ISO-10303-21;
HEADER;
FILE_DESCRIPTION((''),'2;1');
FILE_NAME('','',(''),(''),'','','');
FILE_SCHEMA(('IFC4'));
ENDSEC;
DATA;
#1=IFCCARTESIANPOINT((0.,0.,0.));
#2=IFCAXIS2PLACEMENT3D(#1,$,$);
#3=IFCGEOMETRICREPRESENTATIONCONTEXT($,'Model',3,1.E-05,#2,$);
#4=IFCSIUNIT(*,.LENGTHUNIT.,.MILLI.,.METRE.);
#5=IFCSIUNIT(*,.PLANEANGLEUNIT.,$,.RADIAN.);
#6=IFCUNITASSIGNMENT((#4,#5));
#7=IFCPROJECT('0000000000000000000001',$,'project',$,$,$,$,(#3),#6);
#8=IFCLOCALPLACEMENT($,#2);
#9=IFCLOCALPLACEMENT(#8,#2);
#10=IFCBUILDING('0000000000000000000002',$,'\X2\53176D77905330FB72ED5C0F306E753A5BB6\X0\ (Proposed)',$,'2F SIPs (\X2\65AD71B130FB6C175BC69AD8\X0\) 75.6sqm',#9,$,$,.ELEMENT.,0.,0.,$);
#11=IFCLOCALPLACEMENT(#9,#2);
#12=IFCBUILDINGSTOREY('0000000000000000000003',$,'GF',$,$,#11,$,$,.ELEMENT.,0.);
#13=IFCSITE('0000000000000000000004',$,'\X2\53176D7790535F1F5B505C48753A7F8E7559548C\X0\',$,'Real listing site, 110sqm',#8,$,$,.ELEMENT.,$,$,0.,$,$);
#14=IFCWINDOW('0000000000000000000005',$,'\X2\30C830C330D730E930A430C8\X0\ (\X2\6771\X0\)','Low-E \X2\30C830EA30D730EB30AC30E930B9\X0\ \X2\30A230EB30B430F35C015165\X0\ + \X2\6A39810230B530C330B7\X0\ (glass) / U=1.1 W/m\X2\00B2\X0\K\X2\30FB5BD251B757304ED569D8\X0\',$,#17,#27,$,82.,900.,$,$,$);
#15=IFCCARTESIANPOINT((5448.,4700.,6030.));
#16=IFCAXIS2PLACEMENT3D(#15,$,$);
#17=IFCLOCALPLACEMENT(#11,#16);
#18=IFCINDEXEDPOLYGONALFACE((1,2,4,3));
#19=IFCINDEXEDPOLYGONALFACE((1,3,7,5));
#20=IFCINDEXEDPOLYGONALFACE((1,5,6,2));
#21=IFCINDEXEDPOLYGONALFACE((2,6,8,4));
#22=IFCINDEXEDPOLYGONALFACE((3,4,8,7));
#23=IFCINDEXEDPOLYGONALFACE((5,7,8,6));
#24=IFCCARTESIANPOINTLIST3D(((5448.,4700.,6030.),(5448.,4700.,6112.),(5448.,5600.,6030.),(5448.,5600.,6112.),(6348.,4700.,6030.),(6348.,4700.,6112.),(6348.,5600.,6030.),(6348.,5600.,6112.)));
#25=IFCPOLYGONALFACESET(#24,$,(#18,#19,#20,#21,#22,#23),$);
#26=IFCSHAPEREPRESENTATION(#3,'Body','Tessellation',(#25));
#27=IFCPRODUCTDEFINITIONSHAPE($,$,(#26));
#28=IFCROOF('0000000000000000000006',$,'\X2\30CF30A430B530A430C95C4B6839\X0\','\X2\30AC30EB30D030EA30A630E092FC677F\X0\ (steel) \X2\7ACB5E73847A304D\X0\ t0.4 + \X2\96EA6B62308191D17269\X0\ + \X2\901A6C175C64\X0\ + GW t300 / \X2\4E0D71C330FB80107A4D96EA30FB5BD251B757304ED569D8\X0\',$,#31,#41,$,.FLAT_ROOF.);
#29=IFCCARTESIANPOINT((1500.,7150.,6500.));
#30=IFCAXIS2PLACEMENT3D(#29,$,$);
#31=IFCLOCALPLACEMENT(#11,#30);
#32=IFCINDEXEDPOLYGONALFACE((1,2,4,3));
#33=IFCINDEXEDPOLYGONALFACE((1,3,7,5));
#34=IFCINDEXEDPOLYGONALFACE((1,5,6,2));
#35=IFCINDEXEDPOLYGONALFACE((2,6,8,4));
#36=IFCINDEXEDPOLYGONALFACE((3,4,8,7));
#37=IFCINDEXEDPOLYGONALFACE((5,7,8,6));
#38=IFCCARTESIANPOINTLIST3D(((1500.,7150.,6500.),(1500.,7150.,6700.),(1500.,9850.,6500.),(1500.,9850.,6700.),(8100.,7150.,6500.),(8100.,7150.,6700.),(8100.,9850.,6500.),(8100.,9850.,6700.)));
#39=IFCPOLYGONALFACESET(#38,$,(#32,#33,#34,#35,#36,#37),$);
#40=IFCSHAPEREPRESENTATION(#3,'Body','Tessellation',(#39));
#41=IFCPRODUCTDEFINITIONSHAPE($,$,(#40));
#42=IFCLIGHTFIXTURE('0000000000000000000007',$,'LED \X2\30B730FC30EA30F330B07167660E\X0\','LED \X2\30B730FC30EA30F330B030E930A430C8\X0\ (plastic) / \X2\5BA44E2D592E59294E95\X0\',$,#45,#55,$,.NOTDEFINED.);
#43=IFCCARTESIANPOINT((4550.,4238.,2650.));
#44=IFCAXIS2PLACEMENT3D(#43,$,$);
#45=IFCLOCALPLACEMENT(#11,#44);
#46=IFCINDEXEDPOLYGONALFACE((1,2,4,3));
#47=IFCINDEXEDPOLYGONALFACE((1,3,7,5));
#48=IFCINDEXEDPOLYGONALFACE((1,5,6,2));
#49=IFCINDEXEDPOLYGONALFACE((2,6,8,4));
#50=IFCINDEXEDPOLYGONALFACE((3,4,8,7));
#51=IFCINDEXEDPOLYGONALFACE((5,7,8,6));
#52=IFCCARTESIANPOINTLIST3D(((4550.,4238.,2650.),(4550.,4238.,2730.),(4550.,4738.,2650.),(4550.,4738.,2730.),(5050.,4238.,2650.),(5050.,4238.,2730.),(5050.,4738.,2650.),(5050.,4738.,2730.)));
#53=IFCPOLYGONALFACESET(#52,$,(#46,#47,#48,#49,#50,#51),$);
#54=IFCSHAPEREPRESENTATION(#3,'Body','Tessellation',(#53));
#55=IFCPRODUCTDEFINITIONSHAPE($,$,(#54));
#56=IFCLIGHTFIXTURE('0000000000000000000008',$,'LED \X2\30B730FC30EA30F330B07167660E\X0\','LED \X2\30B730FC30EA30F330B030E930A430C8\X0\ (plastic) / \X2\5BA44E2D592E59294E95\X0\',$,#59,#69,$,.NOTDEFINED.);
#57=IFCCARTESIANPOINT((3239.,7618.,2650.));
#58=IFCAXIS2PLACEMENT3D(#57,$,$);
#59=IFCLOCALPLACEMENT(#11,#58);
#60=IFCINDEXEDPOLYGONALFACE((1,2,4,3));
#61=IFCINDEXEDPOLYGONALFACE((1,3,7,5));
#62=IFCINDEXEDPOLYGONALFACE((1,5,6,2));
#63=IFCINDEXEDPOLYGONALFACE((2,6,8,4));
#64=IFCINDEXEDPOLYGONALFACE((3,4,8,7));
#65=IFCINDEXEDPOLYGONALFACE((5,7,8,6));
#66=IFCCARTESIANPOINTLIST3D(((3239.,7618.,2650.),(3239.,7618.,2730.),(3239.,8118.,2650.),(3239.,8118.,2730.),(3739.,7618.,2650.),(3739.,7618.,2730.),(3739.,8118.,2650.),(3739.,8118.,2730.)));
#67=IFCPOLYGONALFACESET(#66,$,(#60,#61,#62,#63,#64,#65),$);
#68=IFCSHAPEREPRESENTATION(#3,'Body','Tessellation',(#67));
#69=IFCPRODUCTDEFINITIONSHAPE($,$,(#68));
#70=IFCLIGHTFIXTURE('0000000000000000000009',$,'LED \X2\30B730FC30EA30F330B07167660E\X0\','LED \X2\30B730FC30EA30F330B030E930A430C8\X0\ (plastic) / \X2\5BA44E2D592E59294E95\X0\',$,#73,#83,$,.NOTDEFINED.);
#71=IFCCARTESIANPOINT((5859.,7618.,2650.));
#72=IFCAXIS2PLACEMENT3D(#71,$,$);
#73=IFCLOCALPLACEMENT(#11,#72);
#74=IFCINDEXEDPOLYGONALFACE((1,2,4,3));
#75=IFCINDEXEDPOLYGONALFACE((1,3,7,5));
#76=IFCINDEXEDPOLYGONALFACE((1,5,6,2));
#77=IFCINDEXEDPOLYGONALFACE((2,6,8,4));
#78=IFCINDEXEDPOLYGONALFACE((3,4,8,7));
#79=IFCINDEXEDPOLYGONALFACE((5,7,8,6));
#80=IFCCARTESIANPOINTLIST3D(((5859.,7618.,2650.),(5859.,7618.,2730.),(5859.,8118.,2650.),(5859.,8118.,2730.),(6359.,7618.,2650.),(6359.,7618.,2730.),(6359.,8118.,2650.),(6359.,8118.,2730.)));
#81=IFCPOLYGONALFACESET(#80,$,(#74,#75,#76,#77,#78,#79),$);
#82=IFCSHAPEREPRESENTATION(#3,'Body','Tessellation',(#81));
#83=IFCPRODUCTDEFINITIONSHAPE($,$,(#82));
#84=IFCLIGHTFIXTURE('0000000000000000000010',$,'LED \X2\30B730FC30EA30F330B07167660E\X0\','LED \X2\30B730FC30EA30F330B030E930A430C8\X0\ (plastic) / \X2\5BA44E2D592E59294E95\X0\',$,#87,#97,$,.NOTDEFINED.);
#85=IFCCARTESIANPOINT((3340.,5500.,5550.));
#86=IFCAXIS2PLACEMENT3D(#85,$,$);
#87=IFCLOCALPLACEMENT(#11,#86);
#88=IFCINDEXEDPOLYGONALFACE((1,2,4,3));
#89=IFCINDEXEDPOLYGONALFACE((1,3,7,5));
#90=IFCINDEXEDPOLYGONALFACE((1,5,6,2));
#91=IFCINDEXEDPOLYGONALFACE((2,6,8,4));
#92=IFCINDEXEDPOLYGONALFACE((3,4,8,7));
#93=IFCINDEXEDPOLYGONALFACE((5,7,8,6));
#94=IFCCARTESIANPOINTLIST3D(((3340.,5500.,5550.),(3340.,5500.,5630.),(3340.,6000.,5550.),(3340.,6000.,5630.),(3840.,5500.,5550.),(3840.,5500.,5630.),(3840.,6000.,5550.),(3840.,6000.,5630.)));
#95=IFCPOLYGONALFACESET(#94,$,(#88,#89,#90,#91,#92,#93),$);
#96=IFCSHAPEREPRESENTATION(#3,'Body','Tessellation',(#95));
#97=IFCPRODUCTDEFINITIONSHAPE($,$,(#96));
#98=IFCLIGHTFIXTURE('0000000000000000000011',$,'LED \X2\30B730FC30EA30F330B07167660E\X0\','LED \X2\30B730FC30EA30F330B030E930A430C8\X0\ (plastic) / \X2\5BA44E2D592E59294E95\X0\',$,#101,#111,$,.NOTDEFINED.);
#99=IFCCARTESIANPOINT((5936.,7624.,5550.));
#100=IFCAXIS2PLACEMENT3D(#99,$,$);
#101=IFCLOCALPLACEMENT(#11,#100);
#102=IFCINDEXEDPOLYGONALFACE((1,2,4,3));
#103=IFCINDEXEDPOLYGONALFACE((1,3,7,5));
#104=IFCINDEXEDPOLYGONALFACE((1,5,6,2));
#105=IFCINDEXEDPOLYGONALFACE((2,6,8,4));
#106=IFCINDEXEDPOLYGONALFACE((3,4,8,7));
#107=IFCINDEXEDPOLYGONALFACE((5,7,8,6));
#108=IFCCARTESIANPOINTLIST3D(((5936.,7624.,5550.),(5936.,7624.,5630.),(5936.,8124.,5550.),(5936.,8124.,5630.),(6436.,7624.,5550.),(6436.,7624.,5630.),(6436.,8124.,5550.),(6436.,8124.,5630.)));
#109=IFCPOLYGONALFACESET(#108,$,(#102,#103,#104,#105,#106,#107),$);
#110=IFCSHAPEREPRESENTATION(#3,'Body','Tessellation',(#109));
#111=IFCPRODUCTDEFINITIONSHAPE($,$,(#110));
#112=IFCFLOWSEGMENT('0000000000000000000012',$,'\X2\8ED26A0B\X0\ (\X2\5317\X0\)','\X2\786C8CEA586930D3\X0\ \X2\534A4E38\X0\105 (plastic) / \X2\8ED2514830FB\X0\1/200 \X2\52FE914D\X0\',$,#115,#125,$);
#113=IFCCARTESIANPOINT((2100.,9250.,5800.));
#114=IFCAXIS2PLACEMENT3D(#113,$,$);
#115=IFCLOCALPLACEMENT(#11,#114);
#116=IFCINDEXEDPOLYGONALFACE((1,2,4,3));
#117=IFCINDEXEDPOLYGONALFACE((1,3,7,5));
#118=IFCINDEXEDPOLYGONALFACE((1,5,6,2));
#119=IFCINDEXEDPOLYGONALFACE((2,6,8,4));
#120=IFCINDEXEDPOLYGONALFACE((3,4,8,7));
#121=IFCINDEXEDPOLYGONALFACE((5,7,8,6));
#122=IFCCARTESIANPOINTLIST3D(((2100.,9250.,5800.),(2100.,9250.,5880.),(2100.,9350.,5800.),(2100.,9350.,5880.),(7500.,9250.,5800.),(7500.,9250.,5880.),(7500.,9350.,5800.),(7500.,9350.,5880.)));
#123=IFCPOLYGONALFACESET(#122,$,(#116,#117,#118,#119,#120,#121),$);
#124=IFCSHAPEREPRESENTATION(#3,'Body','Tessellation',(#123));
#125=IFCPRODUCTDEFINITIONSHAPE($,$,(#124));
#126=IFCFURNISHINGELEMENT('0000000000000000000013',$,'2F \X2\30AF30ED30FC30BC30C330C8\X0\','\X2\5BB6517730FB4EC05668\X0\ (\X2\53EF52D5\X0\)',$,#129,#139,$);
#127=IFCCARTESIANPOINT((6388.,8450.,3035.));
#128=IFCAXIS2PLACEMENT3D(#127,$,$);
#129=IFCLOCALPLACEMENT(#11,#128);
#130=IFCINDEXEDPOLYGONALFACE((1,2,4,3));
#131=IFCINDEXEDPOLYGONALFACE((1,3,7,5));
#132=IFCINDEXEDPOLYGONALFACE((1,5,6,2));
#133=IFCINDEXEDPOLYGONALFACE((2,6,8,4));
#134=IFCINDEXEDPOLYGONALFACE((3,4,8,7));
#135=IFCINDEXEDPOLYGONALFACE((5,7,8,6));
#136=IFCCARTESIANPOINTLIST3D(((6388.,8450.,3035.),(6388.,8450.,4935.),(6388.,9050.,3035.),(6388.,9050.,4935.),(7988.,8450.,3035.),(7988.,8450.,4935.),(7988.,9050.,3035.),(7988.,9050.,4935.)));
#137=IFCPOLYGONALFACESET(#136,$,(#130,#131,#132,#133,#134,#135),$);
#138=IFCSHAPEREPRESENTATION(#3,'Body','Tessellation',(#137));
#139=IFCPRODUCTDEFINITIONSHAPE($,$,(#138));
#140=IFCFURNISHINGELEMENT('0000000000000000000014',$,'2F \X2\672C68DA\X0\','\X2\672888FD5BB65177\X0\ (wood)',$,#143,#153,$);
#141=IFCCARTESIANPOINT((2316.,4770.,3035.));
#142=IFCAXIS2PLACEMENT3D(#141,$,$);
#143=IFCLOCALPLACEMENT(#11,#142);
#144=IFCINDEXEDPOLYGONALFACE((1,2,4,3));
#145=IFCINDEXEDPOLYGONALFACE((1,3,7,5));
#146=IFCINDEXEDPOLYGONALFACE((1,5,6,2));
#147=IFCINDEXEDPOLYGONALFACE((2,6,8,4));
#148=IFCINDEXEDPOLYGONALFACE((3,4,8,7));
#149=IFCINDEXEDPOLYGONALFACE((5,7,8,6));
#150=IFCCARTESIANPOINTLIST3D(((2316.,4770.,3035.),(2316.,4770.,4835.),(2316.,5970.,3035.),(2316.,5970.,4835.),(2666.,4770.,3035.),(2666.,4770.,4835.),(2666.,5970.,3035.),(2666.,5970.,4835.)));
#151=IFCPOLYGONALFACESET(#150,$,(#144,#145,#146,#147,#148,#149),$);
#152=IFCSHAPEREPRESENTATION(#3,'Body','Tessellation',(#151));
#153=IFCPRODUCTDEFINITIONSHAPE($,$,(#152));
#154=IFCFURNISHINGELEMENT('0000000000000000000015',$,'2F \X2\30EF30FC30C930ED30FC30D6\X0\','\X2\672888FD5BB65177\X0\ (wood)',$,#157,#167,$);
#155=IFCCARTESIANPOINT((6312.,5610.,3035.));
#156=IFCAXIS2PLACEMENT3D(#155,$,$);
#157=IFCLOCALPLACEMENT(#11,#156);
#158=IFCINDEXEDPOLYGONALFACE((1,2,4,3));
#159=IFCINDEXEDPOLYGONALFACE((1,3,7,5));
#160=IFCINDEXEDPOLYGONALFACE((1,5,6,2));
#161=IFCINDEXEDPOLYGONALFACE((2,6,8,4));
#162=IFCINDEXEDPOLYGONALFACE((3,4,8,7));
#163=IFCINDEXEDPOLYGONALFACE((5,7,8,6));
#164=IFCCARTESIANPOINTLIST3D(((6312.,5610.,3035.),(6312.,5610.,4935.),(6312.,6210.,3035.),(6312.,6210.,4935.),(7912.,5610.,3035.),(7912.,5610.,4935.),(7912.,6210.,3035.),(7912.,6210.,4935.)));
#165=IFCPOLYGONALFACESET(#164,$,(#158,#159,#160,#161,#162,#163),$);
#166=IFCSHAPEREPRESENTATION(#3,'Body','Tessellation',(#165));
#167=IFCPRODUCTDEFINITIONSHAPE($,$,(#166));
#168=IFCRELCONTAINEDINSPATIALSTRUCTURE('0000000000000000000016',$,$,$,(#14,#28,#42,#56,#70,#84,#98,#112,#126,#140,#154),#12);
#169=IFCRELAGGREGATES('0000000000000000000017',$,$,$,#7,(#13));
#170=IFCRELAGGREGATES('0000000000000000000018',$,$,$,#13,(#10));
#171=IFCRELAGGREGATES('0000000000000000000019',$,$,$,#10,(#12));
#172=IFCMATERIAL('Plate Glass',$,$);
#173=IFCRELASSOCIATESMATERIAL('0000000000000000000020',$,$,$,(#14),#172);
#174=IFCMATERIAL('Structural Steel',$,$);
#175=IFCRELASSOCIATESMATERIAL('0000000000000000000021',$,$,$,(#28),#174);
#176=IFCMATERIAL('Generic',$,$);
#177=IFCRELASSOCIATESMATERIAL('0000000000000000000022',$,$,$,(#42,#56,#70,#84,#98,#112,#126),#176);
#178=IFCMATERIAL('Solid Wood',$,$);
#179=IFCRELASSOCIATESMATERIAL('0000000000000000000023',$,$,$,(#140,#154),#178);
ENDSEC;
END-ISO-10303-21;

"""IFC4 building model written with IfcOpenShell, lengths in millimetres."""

from ifc_helpers import new_model, si_unit, frame, frame_2d, origin, place, context, project, spatial, rectangle, extrude, material, element, save


model = new_model("IFC4")

# Units and contexts
model_context = context("Model", 3, precision=1e-05, world=origin())
ifc_project = project(units=[si_unit("LENGTHUNIT", "METRE", prefix="MILLI"), si_unit("PLANEANGLEUNIT", "RADIAN")], contexts=[model_context])

# Site, building, storey
site_placement = place(None, origin())
site = spatial("IfcSite", under=ifc_project, at=site_placement, Name="北海道弟子屈町美留和", ObjectType="Real listing site, 110sqm", CompositionType="ELEMENT", RefElevation=0.0)
building_placement = place(site_placement, origin())
building = spatial("IfcBuilding", under=site, at=building_placement, Name="北海道・狭小の町家 (Proposed)", ObjectType="2F SIPs (断熱・気密高) 75.6sqm", CompositionType="ELEMENT", ElevationOfRefHeight=0.0, ElevationOfTerrain=0.0)
storey_placement = place(building_placement, origin())
storey = spatial("IfcBuildingStorey", under=building, at=storey_placement, Name="GF", CompositionType="ELEMENT", Elevation=0.0)

# Shared definitions
ifc_material_1 = material(Name="Solid Wood")

# Shared definitions
ifc_material_2 = material(Name="Plate Glass")

# Window
window_1_placement = place(storey_placement, frame((5448.0, 4700.0, 6030.0)))
element("IfcWindow", 1, at=window_1_placement, inside=storey, material=ifc_material_2, Name="トップライト (東)", Description="Low-E トリプルガラス アルゴン封入 + 樹脂サッシ (glass) / U=1.1 W/m²K・寒冷地仕様", OverallHeight=82.0, OverallWidth=900.0, context=model_context, shape_type="SweptSolid", body=[
    extrude(rectangle(XDim=900.0, YDim=900.0, at=frame_2d((450.0, 450.0))), frame((5448.0, 4700.0, 6030.0)), (0.0, 0.0, 1.0), 82.0),
])

# Roof
ifc_material_3 = material(Name="Structural Steel")
roof_placement = place(storey_placement, frame((1500.0, 7150.0, 6500.0)))
element("IfcRoof", 2, at=roof_placement, inside=storey, material=ifc_material_3, Name="ハイサイド屋根", Description="ガルバリウム鋼板 (steel) 立平葺き t0.4 + 雪止め金物 + 通気層 + GW t300 / 不燃・耐積雪・寒冷地仕様", PredefinedType="FLAT_ROOF", context=model_context, shape_type="SweptSolid", body=[
    extrude(rectangle(XDim=6600.0, YDim=2700.0, at=frame_2d((3300.0, 1350.0))), frame((1500.0, 7150.0, 6500.0)), (0.0, 0.0, 1.0), 200.0),
])

# Light fixtures
ifc_material_4 = material(Name="Generic")
light_fixture_1_placement = place(storey_placement, frame((4550.0, 4238.0, 2650.0)))
element("IfcLightFixture", 3, at=light_fixture_1_placement, inside=storey, material=ifc_material_4, Name="LED シーリング照明", Description="LED シーリングライト (plastic) / 室中央天井", PredefinedType="NOTDEFINED", context=model_context, shape_type="SweptSolid", body=[
    extrude(rectangle(XDim=500.0, YDim=500.0, at=frame_2d((250.0, 250.0))), frame((4550.0, 4238.0, 2650.0)), (0.0, 0.0, 1.0), 80.0),
])
light_fixture_2_placement = place(storey_placement, frame((3239.0, 7618.0, 2650.0)))
element("IfcLightFixture", 4, at=light_fixture_2_placement, inside=storey, material=ifc_material_4, Name="LED シーリング照明", Description="LED シーリングライト (plastic) / 室中央天井", PredefinedType="NOTDEFINED", context=model_context, shape_type="SweptSolid", body=[
    extrude(rectangle(XDim=500.0, YDim=500.0, at=frame_2d((250.0, 250.0))), frame((3239.0, 7618.0, 2650.0)), (0.0, 0.0, 1.0), 80.0),
])
light_fixture_3_placement = place(storey_placement, frame((5859.0, 7618.0, 2650.0)))
element("IfcLightFixture", 5, at=light_fixture_3_placement, inside=storey, material=ifc_material_4, Name="LED シーリング照明", Description="LED シーリングライト (plastic) / 室中央天井", PredefinedType="NOTDEFINED", context=model_context, shape_type="SweptSolid", body=[
    extrude(rectangle(XDim=500.0, YDim=500.0, at=frame_2d((250.0, 250.0))), frame((5859.0, 7618.0, 2650.0)), (0.0, 0.0, 1.0), 80.0),
])
light_fixture_4_placement = place(storey_placement, frame((3340.0, 5500.0, 5550.0)))
element("IfcLightFixture", 6, at=light_fixture_4_placement, inside=storey, material=ifc_material_4, Name="LED シーリング照明", Description="LED シーリングライト (plastic) / 室中央天井", PredefinedType="NOTDEFINED", context=model_context, shape_type="SweptSolid", body=[
    extrude(rectangle(XDim=500.0, YDim=500.0, at=frame_2d((250.0, 250.0))), frame((3340.0, 5500.0, 5550.0)), (0.0, 0.0, 1.0), 80.0),
])
light_fixture_5_placement = place(storey_placement, frame((5936.0, 7624.0, 5550.0)))
element("IfcLightFixture", 7, at=light_fixture_5_placement, inside=storey, material=ifc_material_4, Name="LED シーリング照明", Description="LED シーリングライト (plastic) / 室中央天井", PredefinedType="NOTDEFINED", context=model_context, shape_type="SweptSolid", body=[
    extrude(rectangle(XDim=500.0, YDim=500.0, at=frame_2d((250.0, 250.0))), frame((5936.0, 7624.0, 5550.0)), (0.0, 0.0, 1.0), 80.0),
])

# Flow segment
flow_segment_placement = place(storey_placement, frame((2100.0, 9250.0, 5800.0)))
element("IfcFlowSegment", 8, at=flow_segment_placement, inside=storey, material=ifc_material_4, Name="軒樋 (北)", Description="硬質塩ビ 半丸105 (plastic) / 軒先・1/200 勾配", context=model_context, shape_type="SweptSolid", body=[
    extrude(rectangle(XDim=5400.0, YDim=100.0, at=frame_2d((2700.0, 50.0))), frame((2100.0, 9250.0, 5800.0)), (0.0, 0.0, 1.0), 80.0),
])

# Furnishing elements
furnishing_1_placement = place(storey_placement, frame((6388.0, 8450.0, 3035.0)))
element("IfcFurnishingElement", 9, at=furnishing_1_placement, inside=storey, material=ifc_material_4, Name="2F クローゼット", Description="家具・什器 (可動)", context=model_context, shape_type="SweptSolid", body=[
    extrude(rectangle(XDim=1600.0, YDim=600.0, at=frame_2d((800.0, 300.0))), frame((6388.0, 8450.0, 3035.0)), (0.0, 0.0, 1.0), 1900.0),
])
furnishing_2_placement = place(storey_placement, frame((2316.0, 4770.0, 3035.0)))
element("IfcFurnishingElement", 10, at=furnishing_2_placement, inside=storey, material=ifc_material_1, Name="2F 本棚", Description="木製家具 (wood)", context=model_context, shape_type="SweptSolid", body=[
    extrude(rectangle(XDim=350.0, YDim=1200.0, at=frame_2d((175.0, 600.0))), frame((2316.0, 4770.0, 3035.0)), (0.0, 0.0, 1.0), 1800.0),
])
furnishing_3_placement = place(storey_placement, frame((6312.0, 5610.0, 3035.0)))
element("IfcFurnishingElement", 11, at=furnishing_3_placement, inside=storey, material=ifc_material_1, Name="2F ワードローブ", Description="木製家具 (wood)", context=model_context, shape_type="SweptSolid", body=[
    extrude(rectangle(XDim=1600.0, YDim=600.0, at=frame_2d((800.0, 300.0))), frame((6312.0, 5610.0, 3035.0)), (0.0, 0.0, 1.0), 1900.0),
])

save(model, "model.ifc")
